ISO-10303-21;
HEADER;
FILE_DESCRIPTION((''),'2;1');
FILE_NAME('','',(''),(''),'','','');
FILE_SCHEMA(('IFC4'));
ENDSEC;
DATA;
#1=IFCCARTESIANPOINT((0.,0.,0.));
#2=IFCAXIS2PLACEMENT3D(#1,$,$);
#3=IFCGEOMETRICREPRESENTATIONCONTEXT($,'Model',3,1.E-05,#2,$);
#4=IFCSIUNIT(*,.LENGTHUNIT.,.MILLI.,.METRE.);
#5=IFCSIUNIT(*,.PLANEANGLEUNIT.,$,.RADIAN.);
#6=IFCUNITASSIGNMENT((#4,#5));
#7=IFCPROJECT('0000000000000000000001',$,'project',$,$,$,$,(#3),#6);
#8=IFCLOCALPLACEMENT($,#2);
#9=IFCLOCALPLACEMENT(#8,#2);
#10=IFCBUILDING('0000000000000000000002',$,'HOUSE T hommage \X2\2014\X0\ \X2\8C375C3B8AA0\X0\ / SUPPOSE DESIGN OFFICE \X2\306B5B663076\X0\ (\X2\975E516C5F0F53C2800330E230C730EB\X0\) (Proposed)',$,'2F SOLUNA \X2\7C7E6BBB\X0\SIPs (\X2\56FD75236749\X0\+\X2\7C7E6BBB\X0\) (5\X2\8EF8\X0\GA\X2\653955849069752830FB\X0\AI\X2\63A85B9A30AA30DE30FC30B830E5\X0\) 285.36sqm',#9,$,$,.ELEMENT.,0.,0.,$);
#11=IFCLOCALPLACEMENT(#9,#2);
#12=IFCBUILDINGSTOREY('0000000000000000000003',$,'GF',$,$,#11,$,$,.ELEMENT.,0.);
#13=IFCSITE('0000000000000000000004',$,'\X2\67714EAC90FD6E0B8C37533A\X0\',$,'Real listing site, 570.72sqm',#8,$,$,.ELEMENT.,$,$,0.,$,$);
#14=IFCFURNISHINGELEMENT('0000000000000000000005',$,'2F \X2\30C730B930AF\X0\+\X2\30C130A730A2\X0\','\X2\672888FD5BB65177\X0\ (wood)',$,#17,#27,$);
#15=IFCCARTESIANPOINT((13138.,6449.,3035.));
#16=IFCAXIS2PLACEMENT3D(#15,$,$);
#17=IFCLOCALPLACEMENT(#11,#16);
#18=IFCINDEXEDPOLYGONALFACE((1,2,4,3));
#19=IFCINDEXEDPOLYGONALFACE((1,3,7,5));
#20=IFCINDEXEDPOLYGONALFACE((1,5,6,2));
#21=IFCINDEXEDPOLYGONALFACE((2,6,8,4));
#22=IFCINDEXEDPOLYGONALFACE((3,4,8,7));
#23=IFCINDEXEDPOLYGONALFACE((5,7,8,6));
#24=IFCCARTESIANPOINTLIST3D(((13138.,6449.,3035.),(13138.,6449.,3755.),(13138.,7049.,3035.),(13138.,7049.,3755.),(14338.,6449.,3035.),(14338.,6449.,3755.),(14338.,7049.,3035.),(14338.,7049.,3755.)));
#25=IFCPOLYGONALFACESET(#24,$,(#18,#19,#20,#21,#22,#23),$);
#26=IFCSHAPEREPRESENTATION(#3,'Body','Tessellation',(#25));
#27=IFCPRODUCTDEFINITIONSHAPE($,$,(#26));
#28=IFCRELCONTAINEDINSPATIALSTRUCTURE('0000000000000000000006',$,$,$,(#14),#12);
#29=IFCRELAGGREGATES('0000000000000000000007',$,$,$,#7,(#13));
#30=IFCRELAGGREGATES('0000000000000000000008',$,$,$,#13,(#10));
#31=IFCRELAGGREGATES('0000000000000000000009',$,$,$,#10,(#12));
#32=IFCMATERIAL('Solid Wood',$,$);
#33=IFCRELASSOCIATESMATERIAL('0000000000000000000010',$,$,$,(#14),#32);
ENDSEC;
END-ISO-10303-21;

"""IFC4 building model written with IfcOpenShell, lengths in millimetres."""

from ifc_helpers import new_model, si_unit, frame, frame_2d, origin, place, context, project, spatial, rectangle, extrude, material, element, save


model = new_model("IFC4")

# Units and contexts
model_context = context("Model", 3, precision=1e-05, world=origin())
ifc_project = project(units=[si_unit("LENGTHUNIT", "METRE", prefix="MILLI"), si_unit("PLANEANGLEUNIT", "RADIAN")], contexts=[model_context])

# Site, building, storey
site_placement = place(None, origin())
site = spatial("IfcSite", under=ifc_project, at=site_placement, Name="東京都渋谷区", ObjectType="Real listing site, 570.72sqm", CompositionType="ELEMENT", RefElevation=0.0)
building_placement = place(site_placement, origin())
building = spatial("IfcBuilding", under=site, at=building_placement, Name="HOUSE T hommage — 谷尻誠 / SUPPOSE DESIGN OFFICE に学ぶ (非公式参考モデル) (Proposed)", ObjectType="2F SOLUNA 籾殻SIPs (国産杉+籾殻) (5軸GA改善適用・AI推定オマージュ) 285.36sqm", CompositionType="ELEMENT", ElevationOfRefHeight=0.0, ElevationOfTerrain=0.0)
storey_placement = place(building_placement, origin())
storey = spatial("IfcBuildingStorey", under=building, at=storey_placement, Name="GF", CompositionType="ELEMENT", Elevation=0.0)

# Shared definitions
ifc_material_1 = material(Name="Solid Wood")

# Furnishing element
furnishing_1_placement = place(storey_placement, frame((13138.0, 6449.0, 3035.0)))
element("IfcFurnishingElement", 1, at=furnishing_1_placement, inside=storey, material=ifc_material_1, Name="2F デスク+チェア", Description="木製家具 (wood)", context=model_context, shape_type="SweptSolid", body=[
    extrude(rectangle(XDim=1200.0, YDim=600.0, at=frame_2d((600.0, 300.0))), frame((13138.0, 6449.0, 3035.0)), (0.0, 0.0, 1.0), 720.0),
])

save(model, "model.ifc")
